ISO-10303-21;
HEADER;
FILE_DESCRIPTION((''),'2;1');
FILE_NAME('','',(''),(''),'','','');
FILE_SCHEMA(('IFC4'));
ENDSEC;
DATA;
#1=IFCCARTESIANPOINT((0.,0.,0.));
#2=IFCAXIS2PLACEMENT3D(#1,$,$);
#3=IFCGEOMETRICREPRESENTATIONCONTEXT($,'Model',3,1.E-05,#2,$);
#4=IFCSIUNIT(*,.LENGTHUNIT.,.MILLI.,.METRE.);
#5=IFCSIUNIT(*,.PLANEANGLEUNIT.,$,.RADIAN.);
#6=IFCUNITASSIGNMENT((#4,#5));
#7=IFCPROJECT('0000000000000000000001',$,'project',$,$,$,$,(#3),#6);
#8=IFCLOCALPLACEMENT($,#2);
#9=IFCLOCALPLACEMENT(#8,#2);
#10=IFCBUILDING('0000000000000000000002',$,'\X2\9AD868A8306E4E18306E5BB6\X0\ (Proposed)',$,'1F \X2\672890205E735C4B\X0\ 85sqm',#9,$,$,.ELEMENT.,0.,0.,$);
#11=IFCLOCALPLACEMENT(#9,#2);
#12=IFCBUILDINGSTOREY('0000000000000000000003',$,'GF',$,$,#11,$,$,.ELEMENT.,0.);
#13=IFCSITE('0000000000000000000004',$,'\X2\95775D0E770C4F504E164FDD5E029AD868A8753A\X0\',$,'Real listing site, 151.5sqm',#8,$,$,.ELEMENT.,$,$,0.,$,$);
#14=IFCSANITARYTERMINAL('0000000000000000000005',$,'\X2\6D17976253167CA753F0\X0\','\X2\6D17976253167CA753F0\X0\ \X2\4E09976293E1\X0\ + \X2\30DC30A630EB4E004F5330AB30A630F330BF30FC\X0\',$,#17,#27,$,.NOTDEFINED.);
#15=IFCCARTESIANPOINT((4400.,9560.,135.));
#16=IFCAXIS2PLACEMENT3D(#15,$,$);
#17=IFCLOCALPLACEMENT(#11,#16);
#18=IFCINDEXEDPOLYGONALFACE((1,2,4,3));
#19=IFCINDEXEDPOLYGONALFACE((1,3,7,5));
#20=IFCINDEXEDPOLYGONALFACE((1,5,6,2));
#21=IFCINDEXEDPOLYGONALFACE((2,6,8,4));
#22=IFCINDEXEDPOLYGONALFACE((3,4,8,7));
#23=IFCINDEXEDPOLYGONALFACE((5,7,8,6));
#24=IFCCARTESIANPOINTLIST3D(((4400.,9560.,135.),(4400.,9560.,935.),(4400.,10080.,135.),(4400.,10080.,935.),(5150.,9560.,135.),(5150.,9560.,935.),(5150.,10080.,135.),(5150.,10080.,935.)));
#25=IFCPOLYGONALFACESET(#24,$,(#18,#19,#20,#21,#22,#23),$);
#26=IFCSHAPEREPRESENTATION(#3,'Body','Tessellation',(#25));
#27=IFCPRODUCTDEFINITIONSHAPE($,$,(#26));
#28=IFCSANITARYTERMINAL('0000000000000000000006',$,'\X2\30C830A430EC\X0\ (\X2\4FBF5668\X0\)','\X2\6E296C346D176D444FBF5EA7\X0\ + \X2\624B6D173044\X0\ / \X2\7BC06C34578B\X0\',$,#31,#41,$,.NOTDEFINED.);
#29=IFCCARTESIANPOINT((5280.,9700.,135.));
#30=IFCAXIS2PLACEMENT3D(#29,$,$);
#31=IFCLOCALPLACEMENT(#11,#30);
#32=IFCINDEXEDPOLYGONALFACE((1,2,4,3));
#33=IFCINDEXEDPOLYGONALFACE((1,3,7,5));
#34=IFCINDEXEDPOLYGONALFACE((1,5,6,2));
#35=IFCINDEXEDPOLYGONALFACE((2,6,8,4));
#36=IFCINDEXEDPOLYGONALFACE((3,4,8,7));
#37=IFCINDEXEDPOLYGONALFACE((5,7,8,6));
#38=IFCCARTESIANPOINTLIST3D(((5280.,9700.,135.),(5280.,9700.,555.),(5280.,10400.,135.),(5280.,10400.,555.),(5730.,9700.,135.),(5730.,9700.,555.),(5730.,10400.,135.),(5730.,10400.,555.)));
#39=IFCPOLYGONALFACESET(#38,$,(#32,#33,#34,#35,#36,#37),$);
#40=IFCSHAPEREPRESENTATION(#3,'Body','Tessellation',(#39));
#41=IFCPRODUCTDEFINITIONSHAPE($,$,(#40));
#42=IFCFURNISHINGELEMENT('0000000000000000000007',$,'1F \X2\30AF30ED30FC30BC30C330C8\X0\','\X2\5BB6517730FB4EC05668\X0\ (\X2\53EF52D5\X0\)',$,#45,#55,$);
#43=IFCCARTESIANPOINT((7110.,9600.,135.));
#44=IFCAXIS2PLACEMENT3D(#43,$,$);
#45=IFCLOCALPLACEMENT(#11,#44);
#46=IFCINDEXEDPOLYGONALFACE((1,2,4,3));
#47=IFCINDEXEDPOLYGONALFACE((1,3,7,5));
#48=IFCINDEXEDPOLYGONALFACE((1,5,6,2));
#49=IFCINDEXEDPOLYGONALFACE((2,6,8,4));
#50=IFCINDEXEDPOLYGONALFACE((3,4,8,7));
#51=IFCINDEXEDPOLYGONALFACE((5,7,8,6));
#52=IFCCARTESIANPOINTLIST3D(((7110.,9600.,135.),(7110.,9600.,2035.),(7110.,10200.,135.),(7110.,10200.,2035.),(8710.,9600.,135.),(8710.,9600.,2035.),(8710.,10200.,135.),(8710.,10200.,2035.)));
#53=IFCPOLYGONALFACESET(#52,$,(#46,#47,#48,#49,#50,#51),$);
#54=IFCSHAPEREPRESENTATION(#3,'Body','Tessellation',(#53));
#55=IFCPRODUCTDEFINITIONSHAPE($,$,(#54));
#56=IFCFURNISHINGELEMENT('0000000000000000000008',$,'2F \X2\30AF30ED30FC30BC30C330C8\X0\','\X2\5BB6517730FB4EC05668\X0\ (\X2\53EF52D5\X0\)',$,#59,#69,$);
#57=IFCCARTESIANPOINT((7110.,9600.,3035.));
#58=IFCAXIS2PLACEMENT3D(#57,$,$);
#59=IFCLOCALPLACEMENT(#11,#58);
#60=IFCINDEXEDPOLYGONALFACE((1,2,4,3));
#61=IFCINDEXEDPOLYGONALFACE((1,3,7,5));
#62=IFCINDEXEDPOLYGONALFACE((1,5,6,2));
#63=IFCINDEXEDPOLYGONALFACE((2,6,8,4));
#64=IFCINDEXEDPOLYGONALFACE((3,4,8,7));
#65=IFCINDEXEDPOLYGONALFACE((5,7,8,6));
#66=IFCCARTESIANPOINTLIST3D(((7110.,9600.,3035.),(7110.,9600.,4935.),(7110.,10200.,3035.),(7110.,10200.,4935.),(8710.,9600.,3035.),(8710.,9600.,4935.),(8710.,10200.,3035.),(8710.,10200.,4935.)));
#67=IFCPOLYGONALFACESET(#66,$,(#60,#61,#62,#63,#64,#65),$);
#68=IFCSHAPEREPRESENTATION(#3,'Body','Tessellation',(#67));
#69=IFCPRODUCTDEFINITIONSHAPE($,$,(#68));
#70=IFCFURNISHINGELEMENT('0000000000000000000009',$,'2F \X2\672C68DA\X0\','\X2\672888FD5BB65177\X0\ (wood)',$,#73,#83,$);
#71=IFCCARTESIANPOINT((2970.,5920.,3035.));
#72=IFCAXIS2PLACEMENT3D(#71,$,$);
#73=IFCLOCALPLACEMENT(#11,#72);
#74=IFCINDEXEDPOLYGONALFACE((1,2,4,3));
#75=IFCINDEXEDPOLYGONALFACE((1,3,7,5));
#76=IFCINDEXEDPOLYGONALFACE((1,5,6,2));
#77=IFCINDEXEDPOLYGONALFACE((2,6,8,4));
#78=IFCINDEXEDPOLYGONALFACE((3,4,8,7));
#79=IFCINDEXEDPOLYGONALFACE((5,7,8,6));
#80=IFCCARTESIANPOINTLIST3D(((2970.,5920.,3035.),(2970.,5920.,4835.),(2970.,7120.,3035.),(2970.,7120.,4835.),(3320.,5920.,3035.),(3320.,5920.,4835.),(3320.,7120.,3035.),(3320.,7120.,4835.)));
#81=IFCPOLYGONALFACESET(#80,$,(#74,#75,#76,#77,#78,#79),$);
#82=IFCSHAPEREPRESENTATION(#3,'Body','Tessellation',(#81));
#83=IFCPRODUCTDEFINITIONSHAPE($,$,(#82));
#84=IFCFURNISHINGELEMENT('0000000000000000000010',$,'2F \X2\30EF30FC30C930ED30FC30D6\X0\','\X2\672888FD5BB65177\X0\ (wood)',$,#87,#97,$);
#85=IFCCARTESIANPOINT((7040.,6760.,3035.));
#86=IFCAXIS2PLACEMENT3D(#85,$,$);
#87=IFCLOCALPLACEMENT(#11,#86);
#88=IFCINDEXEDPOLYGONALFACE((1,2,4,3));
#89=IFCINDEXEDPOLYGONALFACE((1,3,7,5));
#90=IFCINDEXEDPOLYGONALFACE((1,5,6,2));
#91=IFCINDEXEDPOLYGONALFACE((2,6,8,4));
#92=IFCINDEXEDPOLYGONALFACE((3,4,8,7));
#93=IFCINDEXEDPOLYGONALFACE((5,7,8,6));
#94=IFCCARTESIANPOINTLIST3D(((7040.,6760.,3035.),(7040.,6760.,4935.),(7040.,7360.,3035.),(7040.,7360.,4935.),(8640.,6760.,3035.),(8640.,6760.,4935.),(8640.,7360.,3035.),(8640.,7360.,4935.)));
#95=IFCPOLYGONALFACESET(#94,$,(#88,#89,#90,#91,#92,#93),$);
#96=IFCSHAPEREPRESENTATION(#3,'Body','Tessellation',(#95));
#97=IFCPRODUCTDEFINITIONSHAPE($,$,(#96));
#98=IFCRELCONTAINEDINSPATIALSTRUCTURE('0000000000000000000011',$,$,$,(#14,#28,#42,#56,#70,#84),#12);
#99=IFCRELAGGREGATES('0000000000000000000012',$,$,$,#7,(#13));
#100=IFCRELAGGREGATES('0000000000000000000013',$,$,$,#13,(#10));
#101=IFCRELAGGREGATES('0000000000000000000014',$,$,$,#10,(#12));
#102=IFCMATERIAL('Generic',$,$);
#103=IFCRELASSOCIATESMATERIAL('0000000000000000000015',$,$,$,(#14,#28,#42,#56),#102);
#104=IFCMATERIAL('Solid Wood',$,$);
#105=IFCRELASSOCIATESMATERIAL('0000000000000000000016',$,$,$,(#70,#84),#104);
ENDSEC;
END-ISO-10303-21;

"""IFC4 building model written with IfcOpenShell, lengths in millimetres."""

from ifc_helpers import new_model, si_unit, frame, frame_2d, origin, place, context, project, spatial, rectangle, extrude, material, element, save


model = new_model("IFC4")

# Units and contexts
model_context = context("Model", 3, precision=1e-05, world=origin())
ifc_project = project(units=[si_unit("LENGTHUNIT", "METRE", prefix="MILLI"), si_unit("PLANEANGLEUNIT", "RADIAN")], contexts=[model_context])

# Site, building, storey
site_placement = place(None, origin())
site = spatial("IfcSite", under=ifc_project, at=site_placement, Name="長崎県佐世保市高梨町", ObjectType="Real listing site, 151.5sqm", CompositionType="ELEMENT", RefElevation=0.0)
building_placement = place(site_placement, origin())
building = spatial("IfcBuilding", under=site, at=building_placement, Name="高梨の丘の家 (Proposed)", ObjectType="1F 木造平屋 85sqm", CompositionType="ELEMENT", ElevationOfRefHeight=0.0, ElevationOfTerrain=0.0)
storey_placement = place(building_placement, origin())
storey = spatial("IfcBuildingStorey", under=building, at=storey_placement, Name="GF", CompositionType="ELEMENT", Elevation=0.0)

# Shared definitions
ifc_material_1 = material(Name="Solid Wood")

# Shared definitions
ifc_material_2 = material(Name="Generic")

# Sanitary terminals
sanitary_terminal_1_placement = place(storey_placement, frame((4400.0, 9560.0, 135.0)))
element("IfcSanitaryTerminal", 1, at=sanitary_terminal_1_placement, inside=storey, material=ifc_material_2, Name="洗面化粧台", Description="洗面化粧台 三面鏡 + ボウル一体カウンター", PredefinedType="NOTDEFINED", context=model_context, shape_type="SweptSolid", body=[
    extrude(rectangle(XDim=750.0, YDim=520.0, at=frame_2d((375.0, 260.0))), frame((4400.0, 9560.0, 135.0)), (0.0, 0.0, 1.0), 800.0),
])
sanitary_terminal_2_placement = place(storey_placement, frame((5280.0, 9700.0, 135.0)))
element("IfcSanitaryTerminal", 2, at=sanitary_terminal_2_placement, inside=storey, material=ifc_material_2, Name="トイレ (便器)", Description="温水洗浄便座 + 手洗い / 節水型", PredefinedType="NOTDEFINED", context=model_context, shape_type="SweptSolid", body=[
    extrude(rectangle(XDim=450.0, YDim=700.0, at=frame_2d((225.0, 350.0))), frame((5280.0, 9700.0, 135.0)), (0.0, 0.0, 1.0), 420.0),
])

# Furnishing elements
furnishing_1_placement = place(storey_placement, frame((7110.0, 9600.0, 135.0)))
element("IfcFurnishingElement", 3, at=furnishing_1_placement, inside=storey, material=ifc_material_2, Name="1F クローゼット", Description="家具・什器 (可動)", context=model_context, shape_type="SweptSolid", body=[
    extrude(rectangle(XDim=1600.0, YDim=600.0, at=frame_2d((800.0, 300.0))), frame((7110.0, 9600.0, 135.0)), (0.0, 0.0, 1.0), 1900.0),
])
furnishing_2_placement = place(storey_placement, frame((7110.0, 9600.0, 3035.0)))
element("IfcFurnishingElement", 4, at=furnishing_2_placement, inside=storey, material=ifc_material_2, Name="2F クローゼット", Description="家具・什器 (可動)", context=model_context, shape_type="SweptSolid", body=[
    extrude(rectangle(XDim=1600.0, YDim=600.0, at=frame_2d((800.0, 300.0))), frame((7110.0, 9600.0, 3035.0)), (0.0, 0.0, 1.0), 1900.0),
])
furnishing_3_placement = place(storey_placement, frame((2970.0, 5920.0, 3035.0)))
element("IfcFurnishingElement", 5, at=furnishing_3_placement, inside=storey, material=ifc_material_1, Name="2F 本棚", Description="木製家具 (wood)", context=model_context, shape_type="SweptSolid", body=[
    extrude(rectangle(XDim=350.0, YDim=1200.0, at=frame_2d((175.0, 600.0))), frame((2970.0, 5920.0, 3035.0)), (0.0, 0.0, 1.0), 1800.0),
])
furnishing_4_placement = place(storey_placement, frame((7040.0, 6760.0, 3035.0)))
element("IfcFurnishingElement", 6, at=furnishing_4_placement, inside=storey, material=ifc_material_1, Name="2F ワードローブ", Description="木製家具 (wood)", context=model_context, shape_type="SweptSolid", body=[
    extrude(rectangle(XDim=1600.0, YDim=600.0, at=frame_2d((800.0, 300.0))), frame((7040.0, 6760.0, 3035.0)), (0.0, 0.0, 1.0), 1900.0),
])

save(model, "model.ifc")
